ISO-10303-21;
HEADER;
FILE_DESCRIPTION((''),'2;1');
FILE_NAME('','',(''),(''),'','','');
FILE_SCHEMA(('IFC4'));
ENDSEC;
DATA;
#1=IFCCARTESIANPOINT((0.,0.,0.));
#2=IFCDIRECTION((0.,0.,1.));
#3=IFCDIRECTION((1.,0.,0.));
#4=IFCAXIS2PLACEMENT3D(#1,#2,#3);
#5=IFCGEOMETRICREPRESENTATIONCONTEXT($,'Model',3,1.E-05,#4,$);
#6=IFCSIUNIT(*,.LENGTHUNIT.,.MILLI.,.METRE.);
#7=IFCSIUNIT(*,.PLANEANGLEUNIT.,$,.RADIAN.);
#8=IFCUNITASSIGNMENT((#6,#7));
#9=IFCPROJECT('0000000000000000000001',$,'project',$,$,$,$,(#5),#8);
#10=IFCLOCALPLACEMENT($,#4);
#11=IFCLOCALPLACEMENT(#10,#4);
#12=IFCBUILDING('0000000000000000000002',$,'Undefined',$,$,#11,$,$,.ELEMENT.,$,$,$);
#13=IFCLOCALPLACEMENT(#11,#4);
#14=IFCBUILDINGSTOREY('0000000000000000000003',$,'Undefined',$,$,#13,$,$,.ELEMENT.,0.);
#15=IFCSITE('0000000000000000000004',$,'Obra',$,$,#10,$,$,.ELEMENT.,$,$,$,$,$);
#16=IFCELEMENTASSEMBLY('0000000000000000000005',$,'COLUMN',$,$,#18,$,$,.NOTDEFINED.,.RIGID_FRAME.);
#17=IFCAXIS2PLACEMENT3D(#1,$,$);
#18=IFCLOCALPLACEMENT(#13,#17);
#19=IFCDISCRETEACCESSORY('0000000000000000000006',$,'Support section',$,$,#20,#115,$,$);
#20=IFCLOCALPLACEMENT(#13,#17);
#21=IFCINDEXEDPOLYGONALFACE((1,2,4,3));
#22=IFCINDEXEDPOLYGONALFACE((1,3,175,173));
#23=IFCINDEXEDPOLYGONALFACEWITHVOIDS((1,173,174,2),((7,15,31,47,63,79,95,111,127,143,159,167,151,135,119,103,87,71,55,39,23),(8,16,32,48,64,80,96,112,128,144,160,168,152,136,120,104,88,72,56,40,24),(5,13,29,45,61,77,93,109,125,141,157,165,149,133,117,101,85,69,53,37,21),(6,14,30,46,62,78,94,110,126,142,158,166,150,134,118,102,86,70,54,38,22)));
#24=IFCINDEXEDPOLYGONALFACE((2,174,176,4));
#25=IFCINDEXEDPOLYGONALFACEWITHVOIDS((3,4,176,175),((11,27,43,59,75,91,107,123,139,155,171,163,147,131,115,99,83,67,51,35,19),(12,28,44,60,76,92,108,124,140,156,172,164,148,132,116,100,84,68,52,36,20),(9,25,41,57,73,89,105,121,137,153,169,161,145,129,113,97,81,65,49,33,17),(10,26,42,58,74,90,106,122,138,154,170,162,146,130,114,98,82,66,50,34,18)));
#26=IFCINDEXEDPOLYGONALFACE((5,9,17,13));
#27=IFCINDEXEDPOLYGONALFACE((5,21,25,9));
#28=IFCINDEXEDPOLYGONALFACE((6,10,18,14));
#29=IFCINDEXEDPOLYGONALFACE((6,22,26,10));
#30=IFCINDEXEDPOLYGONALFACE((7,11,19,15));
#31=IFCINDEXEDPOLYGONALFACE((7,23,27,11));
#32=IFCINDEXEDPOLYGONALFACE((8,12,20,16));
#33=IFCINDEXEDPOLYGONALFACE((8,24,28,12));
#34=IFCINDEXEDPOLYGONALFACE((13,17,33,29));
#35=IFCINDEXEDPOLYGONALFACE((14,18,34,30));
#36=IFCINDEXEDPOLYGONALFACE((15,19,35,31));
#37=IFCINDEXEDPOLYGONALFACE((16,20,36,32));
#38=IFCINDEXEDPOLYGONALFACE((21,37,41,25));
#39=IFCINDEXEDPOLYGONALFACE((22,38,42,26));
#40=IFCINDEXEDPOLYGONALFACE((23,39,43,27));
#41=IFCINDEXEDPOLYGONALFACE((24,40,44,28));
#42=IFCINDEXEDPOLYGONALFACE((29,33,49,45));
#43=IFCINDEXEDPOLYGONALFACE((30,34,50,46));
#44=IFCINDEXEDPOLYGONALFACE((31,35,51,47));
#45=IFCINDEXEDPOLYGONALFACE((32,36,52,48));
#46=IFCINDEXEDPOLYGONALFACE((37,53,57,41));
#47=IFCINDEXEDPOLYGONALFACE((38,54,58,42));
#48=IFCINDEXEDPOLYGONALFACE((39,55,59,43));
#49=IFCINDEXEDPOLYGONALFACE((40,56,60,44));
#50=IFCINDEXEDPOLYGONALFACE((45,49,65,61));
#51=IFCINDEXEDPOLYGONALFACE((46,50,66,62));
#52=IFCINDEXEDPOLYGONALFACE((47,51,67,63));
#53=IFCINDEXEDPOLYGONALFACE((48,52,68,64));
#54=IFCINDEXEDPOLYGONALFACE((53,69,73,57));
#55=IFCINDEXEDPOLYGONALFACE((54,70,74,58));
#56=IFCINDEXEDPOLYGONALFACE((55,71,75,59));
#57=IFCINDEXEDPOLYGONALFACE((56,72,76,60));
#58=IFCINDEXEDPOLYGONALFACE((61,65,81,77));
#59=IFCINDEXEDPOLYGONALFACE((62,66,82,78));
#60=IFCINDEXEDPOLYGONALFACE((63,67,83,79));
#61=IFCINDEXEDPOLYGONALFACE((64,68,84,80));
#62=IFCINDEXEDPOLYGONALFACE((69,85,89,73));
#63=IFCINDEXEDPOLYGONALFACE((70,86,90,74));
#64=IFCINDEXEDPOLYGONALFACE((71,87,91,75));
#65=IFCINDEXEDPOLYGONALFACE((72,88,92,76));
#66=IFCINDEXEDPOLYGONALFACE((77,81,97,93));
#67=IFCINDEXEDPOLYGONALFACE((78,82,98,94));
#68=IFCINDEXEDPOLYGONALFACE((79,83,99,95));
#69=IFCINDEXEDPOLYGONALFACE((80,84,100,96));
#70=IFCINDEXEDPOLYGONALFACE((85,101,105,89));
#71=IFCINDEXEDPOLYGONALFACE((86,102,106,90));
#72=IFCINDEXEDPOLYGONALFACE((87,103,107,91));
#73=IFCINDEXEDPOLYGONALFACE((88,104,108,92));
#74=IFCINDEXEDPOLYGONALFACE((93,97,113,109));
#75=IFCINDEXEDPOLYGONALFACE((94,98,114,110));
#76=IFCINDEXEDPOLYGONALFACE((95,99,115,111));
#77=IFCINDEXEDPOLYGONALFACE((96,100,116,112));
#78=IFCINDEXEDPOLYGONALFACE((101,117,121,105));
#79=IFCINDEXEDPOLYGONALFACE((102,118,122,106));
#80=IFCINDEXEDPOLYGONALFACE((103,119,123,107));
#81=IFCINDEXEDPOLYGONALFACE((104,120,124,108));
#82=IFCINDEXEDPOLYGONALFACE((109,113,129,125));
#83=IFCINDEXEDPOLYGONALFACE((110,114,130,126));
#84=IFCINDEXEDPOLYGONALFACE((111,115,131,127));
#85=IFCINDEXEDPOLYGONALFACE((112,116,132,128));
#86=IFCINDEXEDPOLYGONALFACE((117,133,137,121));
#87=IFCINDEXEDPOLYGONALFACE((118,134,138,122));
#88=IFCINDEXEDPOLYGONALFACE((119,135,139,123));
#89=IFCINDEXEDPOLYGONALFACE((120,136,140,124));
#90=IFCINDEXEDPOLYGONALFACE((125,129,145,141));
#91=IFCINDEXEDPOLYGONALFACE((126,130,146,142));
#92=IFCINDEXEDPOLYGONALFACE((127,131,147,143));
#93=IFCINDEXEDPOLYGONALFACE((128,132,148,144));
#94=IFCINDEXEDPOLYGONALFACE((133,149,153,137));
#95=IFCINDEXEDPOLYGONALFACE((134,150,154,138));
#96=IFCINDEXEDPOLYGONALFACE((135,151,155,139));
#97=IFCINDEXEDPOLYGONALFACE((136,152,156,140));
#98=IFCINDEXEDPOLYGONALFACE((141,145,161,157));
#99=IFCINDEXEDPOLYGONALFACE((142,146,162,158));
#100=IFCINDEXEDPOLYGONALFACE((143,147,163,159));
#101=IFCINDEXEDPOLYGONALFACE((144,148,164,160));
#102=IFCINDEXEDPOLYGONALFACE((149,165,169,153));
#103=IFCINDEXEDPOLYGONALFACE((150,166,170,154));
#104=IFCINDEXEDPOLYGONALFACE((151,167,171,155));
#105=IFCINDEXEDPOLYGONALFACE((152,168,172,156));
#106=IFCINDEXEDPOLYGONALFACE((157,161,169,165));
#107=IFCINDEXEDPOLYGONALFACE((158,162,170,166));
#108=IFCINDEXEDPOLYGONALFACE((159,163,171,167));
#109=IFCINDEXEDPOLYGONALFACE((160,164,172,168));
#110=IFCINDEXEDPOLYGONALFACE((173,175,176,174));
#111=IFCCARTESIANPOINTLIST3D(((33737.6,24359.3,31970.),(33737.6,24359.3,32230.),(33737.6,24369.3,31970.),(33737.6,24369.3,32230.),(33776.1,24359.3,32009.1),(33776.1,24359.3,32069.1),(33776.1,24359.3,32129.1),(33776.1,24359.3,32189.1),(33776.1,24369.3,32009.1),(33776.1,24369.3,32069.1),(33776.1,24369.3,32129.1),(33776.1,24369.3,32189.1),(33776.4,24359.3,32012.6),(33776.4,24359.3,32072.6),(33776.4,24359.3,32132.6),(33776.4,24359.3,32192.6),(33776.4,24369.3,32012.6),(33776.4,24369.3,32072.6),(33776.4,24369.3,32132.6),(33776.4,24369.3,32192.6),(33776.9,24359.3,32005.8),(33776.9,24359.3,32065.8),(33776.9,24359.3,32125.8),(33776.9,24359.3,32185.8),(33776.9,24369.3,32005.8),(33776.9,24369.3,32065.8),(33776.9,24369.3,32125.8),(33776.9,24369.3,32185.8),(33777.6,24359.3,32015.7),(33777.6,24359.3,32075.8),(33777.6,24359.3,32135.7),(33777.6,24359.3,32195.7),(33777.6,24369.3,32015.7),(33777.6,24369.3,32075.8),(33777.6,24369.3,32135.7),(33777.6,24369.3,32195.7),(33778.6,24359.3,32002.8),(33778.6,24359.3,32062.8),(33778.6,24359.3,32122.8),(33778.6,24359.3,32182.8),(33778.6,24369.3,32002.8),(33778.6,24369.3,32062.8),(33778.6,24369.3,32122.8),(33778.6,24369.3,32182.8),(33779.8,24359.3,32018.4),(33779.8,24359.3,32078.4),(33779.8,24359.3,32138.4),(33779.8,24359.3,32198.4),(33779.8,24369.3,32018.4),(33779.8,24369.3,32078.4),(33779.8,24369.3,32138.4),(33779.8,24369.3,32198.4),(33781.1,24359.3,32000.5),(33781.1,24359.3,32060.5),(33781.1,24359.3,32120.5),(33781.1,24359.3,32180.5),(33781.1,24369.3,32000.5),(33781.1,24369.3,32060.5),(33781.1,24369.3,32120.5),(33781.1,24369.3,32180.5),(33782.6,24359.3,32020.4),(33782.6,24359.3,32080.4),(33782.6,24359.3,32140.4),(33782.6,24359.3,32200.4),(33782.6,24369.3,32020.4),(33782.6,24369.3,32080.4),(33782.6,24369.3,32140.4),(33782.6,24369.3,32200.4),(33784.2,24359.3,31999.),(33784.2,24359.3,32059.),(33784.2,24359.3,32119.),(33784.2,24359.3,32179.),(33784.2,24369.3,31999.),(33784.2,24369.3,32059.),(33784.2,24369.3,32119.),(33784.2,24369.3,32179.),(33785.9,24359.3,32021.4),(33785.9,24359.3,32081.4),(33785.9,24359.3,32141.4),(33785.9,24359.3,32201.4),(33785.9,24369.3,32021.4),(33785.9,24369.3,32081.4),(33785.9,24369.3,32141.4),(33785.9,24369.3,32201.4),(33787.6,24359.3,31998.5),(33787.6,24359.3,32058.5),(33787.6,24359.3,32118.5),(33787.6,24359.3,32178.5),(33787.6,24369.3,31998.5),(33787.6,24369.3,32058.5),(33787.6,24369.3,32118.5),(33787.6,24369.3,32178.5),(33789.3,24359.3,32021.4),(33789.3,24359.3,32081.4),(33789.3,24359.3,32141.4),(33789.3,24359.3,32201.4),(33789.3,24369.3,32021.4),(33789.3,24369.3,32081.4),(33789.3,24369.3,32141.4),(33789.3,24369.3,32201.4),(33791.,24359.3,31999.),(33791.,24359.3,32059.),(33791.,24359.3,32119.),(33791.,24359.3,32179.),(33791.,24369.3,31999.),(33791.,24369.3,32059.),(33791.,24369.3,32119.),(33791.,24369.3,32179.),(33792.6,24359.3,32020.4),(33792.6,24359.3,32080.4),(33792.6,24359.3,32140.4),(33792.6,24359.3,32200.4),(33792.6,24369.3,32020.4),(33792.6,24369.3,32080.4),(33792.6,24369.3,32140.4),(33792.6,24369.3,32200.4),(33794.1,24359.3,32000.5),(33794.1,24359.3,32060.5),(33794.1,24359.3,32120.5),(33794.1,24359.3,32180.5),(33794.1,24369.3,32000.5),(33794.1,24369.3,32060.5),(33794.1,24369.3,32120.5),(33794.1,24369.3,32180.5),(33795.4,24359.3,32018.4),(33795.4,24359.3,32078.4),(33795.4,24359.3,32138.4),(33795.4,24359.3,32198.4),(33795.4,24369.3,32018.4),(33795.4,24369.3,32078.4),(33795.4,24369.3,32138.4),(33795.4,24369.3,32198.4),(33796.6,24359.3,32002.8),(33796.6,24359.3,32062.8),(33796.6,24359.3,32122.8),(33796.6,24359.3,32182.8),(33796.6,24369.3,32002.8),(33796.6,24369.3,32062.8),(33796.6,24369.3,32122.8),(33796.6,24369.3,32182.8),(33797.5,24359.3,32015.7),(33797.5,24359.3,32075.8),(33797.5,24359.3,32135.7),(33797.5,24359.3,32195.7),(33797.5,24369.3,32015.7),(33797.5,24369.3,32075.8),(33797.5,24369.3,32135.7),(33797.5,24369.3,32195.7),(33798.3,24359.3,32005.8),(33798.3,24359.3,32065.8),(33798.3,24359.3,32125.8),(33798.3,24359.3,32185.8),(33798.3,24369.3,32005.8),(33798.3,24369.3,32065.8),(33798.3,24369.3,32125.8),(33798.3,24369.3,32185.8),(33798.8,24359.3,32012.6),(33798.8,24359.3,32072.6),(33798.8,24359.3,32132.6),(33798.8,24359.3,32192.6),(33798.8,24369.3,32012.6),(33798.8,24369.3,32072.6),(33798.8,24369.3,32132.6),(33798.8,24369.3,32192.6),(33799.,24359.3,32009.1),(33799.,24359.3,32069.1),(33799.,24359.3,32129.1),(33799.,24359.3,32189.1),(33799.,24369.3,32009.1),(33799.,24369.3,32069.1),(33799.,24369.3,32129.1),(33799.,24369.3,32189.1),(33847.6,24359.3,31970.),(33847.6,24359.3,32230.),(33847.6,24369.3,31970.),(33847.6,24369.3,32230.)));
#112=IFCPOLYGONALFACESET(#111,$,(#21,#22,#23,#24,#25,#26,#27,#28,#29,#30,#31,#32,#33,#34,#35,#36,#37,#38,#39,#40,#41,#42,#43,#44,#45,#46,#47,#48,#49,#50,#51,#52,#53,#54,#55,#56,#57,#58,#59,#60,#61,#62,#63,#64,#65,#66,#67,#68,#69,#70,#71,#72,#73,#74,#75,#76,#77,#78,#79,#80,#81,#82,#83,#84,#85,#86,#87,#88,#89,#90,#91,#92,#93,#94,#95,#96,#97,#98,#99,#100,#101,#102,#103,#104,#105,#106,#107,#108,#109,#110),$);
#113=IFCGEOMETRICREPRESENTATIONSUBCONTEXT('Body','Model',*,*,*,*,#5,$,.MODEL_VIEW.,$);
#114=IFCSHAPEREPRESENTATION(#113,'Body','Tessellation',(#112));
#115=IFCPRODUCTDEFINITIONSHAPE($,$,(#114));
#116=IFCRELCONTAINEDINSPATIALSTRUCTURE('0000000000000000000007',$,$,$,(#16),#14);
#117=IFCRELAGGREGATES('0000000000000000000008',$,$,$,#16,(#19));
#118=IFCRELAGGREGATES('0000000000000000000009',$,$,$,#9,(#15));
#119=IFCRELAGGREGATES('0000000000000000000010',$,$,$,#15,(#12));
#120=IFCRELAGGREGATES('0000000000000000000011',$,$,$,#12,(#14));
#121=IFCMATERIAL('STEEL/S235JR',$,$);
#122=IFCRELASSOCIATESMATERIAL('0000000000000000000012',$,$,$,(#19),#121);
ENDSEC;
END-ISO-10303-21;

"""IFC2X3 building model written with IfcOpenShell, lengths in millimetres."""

from ifc_helpers import new_model, si_unit, frame, origin_with_axes, origin_2d_with_axis, place, context, subcontext, project, spatial, rectangle, circle, extrude, source, transform, mapped, material, element, aggregate, save


model = new_model("IFC2X3")

# Units and contexts
model_context = context("Model", 3, precision=1e-05, world=origin_with_axes())
body_context = subcontext(model_context, "Body", "Model", "MODEL_VIEW")
ifc_project = project(units=[si_unit("LENGTHUNIT", "METRE", prefix="MILLI"), si_unit("PLANEANGLEUNIT", "RADIAN")], contexts=[model_context])

# Site, building, storey
site_placement = place(None, origin_with_axes())
site = spatial("IfcSite", under=ifc_project, at=site_placement, Name="Obra", CompositionType="ELEMENT")
building_placement = place(site_placement, origin_with_axes())
building = spatial("IfcBuilding", under=site, at=building_placement, Name="Undefined", CompositionType="ELEMENT")
storey_placement = place(building_placement, origin_with_axes())
storey = spatial("IfcBuildingStorey", under=building, at=storey_placement, Name="Undefined", CompositionType="ELEMENT", Elevation=0.0)

# Shared definitions
ifc_material_1 = material(Name="STEEL/S235JR")

# Element assembly, discrete accessory, opening
assembly_1_placement = place(storey_placement, origin_with_axes())
assembly_1 = element("IfcElementAssembly", 1, at=assembly_1_placement, inside=storey, Name="COLUMN", AssemblyPlace="NOTDEFINED", PredefinedType="RIGID_FRAME")
discrete_accessory_1_placement = place(assembly_1_placement, frame((33792.6, 24364.3, 31970.0), z_axis=(0.0, 0.0, 1.0), x_axis=(1.0, 0.0, 0.0)))
discrete_accessory_1 = element("IfcDiscreteAccessory", 2, at=discrete_accessory_1_placement, material=ifc_material_1, Name="Support section", context=body_context, shape_type="SweptSolid", body=[
    extrude(rectangle(XDim=10.0, YDim=110.0, at=origin_2d_with_axis()), frame((0.0, 0.0, 260.0), z_axis=(0.0, 0.0, -1.0), x_axis=(0.0, 1.0, 0.0)), (0.0, 0.0, 1.0), 260.0),
])
shared_shape_1 = source(origin_with_axes(), body_context, "Body", "SweptSolid", [
    extrude(circle(Radius=11.5, at=origin_2d_with_axis()), frame((0.0, -14.4, 0.0), z_axis=(0.0, 1.0, 0.0), x_axis=(1.0, 0.0, 0.0)), (0.0, 0.0, 1.0), 10.2),
])
opening_1_placement = place(assembly_1_placement, frame((33837.6, 24355.0, 32300.0), z_axis=(-1.0, 0.0, 0.0), x_axis=(0.0, 0.0, -1.0)))
element("IfcOpeningElement", 3, at=opening_1_placement, cuts=discrete_accessory_1, ObjectType="Opening", context=body_context, shape_type="MappedRepresentation", body=[
    mapped(shared_shape_1, transform((110.0, 0.0, 50.0))),
    mapped(shared_shape_1, transform((170.0, 0.0, 50.0))),
    mapped(shared_shape_1, transform((230.0, 0.0, 50.0))),
    mapped(shared_shape_1, transform((290.0, 0.0, 50.0))),
])
aggregate(assembly_1, [discrete_accessory_1])

save(model, "model.ifc")
